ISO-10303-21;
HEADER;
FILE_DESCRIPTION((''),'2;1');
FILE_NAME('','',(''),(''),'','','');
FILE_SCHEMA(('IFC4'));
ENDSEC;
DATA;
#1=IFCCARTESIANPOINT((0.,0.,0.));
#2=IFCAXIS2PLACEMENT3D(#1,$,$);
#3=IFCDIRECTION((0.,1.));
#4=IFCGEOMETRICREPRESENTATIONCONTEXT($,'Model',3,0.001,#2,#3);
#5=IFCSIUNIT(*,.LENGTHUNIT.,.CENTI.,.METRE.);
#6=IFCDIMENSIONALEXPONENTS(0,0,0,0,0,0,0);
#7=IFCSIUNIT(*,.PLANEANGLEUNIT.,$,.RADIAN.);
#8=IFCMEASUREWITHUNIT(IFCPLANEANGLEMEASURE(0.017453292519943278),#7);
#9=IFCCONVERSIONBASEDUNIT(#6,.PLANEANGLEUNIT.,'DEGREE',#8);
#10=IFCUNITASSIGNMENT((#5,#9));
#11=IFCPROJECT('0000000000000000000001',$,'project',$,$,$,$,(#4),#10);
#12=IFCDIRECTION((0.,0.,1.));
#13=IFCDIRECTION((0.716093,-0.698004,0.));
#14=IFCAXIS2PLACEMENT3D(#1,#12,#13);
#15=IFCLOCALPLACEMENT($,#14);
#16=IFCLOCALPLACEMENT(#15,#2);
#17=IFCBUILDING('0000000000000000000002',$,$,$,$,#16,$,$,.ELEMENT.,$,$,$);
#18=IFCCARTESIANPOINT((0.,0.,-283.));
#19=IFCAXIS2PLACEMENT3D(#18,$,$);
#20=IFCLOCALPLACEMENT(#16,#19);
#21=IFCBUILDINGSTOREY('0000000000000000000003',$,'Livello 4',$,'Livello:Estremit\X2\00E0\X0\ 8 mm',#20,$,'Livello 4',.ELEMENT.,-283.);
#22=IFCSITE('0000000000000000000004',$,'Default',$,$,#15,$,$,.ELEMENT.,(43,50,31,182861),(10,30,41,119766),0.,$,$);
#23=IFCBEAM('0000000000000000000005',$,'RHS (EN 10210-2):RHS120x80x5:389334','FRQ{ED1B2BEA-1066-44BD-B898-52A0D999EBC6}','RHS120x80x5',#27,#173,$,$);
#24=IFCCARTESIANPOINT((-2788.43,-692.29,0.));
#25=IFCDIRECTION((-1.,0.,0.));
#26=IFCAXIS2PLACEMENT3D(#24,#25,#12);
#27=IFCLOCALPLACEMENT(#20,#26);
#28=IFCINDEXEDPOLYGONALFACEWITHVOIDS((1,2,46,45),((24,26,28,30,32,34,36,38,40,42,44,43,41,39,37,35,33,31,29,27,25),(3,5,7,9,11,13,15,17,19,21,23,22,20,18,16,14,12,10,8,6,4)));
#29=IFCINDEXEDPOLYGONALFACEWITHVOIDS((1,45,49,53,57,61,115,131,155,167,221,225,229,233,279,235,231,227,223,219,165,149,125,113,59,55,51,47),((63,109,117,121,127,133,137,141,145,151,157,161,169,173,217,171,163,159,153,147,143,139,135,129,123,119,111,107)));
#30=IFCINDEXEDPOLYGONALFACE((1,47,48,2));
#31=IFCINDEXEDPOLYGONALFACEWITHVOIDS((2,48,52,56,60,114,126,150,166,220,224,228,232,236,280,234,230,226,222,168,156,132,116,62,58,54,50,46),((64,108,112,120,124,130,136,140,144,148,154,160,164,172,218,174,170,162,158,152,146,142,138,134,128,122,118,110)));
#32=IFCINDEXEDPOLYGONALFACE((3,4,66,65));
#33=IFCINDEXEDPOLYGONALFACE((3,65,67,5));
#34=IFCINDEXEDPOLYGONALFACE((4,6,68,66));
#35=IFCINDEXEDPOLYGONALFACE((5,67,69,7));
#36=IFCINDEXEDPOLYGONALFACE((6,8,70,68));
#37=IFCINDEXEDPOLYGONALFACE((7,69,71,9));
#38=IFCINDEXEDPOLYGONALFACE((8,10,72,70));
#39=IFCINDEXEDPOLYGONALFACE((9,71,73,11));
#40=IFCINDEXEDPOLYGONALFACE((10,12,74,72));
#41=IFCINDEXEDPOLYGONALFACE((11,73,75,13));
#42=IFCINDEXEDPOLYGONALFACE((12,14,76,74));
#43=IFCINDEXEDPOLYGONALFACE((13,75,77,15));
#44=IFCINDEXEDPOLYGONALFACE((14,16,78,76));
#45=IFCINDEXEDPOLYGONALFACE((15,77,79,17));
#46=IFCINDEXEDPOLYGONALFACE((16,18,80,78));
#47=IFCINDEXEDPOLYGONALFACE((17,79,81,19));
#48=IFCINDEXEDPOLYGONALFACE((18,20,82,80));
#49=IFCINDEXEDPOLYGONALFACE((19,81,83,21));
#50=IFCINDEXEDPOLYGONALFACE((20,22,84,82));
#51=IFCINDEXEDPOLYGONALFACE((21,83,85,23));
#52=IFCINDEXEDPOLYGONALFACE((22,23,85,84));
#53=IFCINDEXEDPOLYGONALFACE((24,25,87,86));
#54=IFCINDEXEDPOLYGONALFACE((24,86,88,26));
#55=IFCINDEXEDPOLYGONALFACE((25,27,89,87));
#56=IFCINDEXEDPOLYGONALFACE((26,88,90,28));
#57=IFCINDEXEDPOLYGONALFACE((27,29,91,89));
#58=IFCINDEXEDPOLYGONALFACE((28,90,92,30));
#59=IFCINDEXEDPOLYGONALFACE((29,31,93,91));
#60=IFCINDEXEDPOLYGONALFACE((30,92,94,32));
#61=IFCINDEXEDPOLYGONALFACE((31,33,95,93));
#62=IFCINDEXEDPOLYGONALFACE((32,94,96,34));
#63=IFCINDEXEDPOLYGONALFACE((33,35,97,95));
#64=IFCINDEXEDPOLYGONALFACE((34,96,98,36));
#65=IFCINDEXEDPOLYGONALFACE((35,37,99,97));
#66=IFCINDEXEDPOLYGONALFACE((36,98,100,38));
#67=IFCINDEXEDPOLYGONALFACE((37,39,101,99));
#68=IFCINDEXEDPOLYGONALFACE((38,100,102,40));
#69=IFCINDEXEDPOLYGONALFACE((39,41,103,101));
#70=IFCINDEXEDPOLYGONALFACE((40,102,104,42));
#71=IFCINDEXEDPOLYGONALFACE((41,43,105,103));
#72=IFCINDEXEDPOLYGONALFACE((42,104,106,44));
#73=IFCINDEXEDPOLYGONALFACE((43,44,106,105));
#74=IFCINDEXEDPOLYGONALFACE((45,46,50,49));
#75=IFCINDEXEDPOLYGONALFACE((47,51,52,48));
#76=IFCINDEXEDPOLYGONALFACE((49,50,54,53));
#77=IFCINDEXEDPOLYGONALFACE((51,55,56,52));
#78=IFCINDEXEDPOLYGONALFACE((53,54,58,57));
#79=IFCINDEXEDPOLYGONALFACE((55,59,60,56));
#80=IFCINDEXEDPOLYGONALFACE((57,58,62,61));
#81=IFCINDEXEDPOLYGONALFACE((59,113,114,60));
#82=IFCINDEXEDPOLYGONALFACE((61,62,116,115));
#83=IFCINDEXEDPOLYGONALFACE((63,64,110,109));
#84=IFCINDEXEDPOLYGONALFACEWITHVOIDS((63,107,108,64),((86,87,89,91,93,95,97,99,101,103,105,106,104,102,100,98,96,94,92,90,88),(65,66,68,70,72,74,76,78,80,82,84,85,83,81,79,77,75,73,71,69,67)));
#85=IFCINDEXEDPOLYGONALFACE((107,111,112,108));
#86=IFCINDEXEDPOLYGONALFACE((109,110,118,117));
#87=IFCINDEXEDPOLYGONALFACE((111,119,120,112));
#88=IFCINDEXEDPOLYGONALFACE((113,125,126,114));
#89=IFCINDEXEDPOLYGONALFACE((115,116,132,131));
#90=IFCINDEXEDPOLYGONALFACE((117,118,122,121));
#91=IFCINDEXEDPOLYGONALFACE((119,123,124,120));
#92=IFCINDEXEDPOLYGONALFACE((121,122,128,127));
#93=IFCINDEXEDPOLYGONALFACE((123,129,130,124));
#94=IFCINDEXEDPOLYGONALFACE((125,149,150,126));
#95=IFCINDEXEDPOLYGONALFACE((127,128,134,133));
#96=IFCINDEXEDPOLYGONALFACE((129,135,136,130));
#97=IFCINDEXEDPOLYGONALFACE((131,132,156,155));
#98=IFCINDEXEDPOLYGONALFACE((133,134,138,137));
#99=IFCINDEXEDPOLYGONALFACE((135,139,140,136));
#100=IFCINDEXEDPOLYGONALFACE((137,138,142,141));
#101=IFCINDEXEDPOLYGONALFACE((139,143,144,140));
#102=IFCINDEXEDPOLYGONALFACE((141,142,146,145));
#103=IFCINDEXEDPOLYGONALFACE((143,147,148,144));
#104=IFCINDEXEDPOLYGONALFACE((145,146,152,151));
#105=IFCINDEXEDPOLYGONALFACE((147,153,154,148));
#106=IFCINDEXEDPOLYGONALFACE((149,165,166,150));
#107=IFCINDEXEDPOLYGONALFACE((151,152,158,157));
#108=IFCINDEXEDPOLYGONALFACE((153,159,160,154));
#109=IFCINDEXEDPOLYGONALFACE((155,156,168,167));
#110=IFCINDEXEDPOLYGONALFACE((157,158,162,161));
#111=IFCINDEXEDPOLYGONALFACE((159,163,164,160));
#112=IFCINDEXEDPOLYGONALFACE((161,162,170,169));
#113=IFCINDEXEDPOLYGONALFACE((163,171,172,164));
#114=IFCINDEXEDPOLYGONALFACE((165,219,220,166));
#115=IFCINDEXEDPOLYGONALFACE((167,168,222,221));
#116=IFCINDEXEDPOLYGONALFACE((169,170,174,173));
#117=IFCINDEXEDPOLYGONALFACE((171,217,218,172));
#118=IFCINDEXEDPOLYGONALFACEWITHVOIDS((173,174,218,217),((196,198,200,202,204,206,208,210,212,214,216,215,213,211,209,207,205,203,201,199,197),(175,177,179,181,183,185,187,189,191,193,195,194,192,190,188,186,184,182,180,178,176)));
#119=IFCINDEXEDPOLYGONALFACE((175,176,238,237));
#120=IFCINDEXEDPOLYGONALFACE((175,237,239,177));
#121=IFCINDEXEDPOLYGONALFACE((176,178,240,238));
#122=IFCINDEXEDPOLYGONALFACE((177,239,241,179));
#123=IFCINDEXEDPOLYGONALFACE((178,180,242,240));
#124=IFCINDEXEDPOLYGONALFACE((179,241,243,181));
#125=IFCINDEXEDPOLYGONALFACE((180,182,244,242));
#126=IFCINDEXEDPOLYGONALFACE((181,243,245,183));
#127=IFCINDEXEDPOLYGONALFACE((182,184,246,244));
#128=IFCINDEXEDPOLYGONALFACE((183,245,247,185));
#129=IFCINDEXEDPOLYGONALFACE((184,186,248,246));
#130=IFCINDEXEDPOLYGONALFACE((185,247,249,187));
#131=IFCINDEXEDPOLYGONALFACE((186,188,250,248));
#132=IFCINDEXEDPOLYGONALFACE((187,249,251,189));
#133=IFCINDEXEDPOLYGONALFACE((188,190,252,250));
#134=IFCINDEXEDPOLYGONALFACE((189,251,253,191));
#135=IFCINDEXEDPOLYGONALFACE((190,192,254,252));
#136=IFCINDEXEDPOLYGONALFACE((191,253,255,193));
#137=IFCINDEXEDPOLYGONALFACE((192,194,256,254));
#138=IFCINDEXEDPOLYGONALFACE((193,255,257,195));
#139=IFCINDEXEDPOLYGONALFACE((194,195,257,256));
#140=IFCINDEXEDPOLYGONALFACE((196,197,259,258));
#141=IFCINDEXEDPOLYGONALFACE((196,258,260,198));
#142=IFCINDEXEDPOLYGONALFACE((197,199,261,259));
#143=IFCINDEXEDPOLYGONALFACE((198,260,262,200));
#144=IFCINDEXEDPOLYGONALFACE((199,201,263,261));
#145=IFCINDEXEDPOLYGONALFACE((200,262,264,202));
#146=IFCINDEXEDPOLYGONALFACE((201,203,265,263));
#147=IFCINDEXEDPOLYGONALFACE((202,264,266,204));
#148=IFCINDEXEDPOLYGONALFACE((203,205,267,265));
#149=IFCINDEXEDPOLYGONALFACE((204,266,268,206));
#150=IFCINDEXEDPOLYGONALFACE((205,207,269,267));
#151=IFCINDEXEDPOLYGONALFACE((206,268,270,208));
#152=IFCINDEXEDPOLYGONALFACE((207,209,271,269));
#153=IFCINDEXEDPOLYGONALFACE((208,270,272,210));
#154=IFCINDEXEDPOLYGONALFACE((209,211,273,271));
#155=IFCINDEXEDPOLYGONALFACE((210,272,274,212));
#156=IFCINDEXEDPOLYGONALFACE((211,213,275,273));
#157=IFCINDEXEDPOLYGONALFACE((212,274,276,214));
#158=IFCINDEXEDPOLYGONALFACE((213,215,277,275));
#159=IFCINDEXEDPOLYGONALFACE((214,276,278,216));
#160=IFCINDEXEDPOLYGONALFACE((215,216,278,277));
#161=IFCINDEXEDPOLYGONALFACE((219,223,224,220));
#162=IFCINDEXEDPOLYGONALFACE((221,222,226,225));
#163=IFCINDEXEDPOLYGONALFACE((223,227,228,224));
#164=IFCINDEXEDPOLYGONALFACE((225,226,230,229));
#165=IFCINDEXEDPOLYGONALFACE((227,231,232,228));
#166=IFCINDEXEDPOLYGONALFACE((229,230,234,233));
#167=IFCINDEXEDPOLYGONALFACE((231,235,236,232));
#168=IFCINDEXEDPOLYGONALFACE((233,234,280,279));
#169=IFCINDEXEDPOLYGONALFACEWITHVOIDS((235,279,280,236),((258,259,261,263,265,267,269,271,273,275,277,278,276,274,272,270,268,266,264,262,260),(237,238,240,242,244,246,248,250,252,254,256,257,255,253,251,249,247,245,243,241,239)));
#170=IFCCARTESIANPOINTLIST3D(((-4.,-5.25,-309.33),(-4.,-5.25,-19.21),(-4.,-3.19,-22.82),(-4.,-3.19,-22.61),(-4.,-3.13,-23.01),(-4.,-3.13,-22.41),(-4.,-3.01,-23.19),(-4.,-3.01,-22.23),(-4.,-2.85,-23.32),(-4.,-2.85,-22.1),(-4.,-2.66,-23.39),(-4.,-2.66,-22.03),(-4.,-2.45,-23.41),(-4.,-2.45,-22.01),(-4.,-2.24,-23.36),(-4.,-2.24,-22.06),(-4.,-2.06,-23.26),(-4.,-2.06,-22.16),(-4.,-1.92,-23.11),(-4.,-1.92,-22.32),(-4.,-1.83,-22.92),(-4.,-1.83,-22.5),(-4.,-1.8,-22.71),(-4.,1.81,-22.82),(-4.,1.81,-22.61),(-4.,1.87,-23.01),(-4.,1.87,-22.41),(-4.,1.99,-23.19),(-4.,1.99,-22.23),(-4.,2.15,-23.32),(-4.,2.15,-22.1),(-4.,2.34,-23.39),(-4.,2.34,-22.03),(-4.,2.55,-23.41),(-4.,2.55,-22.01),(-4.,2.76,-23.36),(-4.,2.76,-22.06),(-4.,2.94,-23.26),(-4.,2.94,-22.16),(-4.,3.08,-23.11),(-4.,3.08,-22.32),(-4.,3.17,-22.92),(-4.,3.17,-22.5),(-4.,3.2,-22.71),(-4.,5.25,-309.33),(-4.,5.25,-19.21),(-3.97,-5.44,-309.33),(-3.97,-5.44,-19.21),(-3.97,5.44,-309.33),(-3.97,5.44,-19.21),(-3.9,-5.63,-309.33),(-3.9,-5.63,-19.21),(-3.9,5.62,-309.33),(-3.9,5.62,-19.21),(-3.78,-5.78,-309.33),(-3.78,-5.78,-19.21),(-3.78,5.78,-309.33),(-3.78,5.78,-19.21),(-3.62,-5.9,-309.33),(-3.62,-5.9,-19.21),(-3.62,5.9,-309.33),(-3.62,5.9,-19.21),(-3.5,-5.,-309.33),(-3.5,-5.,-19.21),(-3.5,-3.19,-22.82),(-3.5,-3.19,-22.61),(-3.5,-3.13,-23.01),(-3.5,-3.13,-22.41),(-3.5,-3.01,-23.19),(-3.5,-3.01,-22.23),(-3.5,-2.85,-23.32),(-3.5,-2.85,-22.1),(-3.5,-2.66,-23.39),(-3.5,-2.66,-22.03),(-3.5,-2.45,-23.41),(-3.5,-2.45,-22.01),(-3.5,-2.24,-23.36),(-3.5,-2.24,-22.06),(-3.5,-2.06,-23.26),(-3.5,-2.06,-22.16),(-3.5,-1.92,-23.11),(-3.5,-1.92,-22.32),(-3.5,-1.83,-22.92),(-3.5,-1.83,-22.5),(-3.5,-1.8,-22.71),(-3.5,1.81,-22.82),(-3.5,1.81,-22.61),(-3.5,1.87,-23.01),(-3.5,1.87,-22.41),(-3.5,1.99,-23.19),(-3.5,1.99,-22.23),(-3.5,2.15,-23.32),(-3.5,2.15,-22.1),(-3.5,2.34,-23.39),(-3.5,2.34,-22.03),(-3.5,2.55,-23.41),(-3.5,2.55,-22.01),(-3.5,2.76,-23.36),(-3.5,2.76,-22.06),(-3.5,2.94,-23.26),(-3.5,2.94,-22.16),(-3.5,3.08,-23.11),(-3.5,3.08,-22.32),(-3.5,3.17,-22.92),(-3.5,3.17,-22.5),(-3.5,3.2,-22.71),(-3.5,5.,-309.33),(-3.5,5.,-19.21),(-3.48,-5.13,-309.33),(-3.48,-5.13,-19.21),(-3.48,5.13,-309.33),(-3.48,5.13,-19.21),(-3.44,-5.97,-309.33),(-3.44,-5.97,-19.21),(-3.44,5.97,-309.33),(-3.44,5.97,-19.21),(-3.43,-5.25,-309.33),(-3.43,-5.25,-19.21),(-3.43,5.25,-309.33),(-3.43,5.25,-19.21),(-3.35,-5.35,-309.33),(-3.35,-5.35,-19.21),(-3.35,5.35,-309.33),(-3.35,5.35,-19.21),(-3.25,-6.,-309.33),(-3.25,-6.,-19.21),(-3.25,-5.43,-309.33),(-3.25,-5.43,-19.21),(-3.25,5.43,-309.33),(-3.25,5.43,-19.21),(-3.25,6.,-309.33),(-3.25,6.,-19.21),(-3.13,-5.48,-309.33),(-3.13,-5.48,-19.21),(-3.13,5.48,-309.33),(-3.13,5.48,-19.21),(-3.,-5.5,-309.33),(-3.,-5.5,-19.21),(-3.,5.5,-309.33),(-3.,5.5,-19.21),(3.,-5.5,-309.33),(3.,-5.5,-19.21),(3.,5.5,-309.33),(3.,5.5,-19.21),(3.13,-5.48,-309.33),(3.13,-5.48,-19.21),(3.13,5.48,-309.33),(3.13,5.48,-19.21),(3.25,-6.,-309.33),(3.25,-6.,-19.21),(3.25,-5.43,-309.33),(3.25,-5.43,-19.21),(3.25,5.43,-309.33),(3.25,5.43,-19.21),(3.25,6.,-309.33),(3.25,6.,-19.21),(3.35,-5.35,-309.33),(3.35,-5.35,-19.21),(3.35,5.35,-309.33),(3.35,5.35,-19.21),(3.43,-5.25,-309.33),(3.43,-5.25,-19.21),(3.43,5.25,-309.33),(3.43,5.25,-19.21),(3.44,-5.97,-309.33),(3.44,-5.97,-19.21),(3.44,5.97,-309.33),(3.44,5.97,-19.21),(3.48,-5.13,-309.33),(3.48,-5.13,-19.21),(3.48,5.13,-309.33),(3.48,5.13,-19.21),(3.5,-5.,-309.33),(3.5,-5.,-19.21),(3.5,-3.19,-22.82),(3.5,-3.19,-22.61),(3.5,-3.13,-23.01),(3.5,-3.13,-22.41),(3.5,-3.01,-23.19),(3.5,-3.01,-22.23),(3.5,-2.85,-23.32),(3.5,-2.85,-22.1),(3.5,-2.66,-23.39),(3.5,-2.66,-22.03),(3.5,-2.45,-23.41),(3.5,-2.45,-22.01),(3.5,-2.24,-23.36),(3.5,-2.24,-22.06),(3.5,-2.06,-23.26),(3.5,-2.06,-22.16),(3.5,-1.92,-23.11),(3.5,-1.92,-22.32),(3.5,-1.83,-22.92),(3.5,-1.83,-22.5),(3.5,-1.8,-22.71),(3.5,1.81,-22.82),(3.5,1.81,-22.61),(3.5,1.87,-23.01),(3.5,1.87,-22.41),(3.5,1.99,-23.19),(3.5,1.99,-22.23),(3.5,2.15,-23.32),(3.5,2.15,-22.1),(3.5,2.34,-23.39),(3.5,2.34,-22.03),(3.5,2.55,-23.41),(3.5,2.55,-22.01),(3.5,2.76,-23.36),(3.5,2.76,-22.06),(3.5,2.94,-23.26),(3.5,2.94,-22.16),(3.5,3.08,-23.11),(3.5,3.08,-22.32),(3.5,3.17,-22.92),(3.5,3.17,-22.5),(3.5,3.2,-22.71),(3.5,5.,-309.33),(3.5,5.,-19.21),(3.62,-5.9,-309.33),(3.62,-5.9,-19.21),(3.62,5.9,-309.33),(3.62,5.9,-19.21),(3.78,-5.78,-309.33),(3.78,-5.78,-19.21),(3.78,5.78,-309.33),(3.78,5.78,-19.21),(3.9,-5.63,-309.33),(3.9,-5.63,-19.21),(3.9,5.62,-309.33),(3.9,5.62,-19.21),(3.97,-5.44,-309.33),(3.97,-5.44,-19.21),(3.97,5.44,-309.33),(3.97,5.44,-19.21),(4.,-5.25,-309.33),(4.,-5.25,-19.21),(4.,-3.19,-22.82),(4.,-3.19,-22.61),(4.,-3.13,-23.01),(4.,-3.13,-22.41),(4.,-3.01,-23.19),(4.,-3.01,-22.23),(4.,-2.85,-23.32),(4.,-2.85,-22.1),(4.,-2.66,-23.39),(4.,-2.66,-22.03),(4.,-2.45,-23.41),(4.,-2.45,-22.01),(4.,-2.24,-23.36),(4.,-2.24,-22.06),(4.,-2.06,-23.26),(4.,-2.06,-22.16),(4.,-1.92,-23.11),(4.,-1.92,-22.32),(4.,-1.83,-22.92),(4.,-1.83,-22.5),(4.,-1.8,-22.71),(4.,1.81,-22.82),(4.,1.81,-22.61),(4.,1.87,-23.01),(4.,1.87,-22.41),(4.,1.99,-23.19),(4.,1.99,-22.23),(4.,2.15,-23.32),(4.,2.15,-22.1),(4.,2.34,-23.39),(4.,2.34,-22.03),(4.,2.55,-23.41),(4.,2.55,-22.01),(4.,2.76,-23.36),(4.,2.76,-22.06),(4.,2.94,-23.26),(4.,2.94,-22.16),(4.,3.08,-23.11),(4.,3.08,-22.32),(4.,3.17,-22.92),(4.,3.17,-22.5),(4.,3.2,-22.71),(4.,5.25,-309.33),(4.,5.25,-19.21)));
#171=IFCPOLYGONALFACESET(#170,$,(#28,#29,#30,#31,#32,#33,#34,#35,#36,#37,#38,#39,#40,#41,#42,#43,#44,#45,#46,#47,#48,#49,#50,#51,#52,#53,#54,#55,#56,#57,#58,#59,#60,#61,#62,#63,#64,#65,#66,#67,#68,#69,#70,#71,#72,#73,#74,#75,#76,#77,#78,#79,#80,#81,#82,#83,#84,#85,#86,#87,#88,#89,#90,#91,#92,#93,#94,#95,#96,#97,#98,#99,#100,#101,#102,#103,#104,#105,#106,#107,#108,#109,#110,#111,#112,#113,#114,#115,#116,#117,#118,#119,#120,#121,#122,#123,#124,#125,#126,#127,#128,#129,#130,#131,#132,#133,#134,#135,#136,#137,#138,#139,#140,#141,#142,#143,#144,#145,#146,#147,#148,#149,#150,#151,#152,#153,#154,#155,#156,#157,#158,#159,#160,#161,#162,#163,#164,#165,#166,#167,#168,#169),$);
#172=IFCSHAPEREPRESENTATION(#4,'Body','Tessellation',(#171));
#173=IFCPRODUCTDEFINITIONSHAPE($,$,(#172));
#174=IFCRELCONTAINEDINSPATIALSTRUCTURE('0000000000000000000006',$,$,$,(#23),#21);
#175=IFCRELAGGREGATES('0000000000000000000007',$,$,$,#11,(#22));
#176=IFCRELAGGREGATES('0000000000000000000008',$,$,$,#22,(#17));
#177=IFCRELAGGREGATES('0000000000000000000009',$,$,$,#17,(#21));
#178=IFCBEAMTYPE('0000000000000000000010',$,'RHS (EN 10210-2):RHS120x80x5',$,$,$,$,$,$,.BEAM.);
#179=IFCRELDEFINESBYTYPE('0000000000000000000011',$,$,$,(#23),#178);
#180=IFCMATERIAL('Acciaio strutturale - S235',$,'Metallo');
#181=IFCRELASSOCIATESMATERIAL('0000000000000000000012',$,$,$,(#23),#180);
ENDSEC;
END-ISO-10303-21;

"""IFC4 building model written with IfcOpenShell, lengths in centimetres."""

from ifc_helpers import new_model, entity, si_unit, converted_unit, direction, frame, frame_2d, origin, origin_2d, place, context, project, spatial, hollow_rectangle, circle, extrude, clip, halfspace, material, type_object, element, save


model = new_model("IFC4")

# Units and contexts
model_context = context("Model", 3, precision=0.001, world=origin(), true_north=direction((0.0, 1.0)))
ifc_project = project(units=[si_unit("LENGTHUNIT", "METRE", prefix="CENTI"), converted_unit("PLANEANGLEUNIT", "DEGREE", entity("IfcPlaneAngleMeasure", 0.017453292519943278), si_unit("PLANEANGLEUNIT", "RADIAN"), dimensions=[0, 0, 0, 0, 0, 0, 0])], contexts=[model_context])

# Site, building, storey
site_placement = place(None, frame((0.0, 0.0, 0.0), z_axis=(0.0, 0.0, 1.0), x_axis=(0.716093, -0.698004, 0.0)))
site = spatial("IfcSite", under=ifc_project, at=site_placement, Name="Default", CompositionType="ELEMENT", RefLatitude=(43, 50, 31, 182861), RefLongitude=(10, 30, 41, 119766), RefElevation=0.0)
building_placement = place(site_placement, origin())
building = spatial("IfcBuilding", under=site, at=building_placement, CompositionType="ELEMENT")
storey_placement = place(building_placement, frame((0.0, 0.0, -283.0)))
storey = spatial("IfcBuildingStorey", under=building, at=storey_placement, Name="Livello 4", ObjectType="Livello:Estremità 8 mm", LongName="Livello 4", CompositionType="ELEMENT", Elevation=-283.0)

# Shared definitions
ifc_material = material(Name="Acciaio strutturale - S235", Category="Metallo")

# Beam, openings
beam_type = type_object("IfcBeamType", Name="RHS (EN 10210-2):RHS120x80x5", PredefinedType="BEAM")
beam_1_placement = place(storey_placement, frame((-2788.43, -692.29, 0.0), z_axis=(-1.0, 0.0, 0.0), x_axis=(0.0, 0.0, 1.0)))
beam_1 = element("IfcBeam", 1, at=beam_1_placement, inside=storey, type_object=beam_type, material=ifc_material, Name="RHS (EN 10210-2):RHS120x80x5:389334", Description="FRQ{ED1B2BEA-1066-44BD-B898-52A0D999EBC6}", ObjectType="RHS120x80x5", context=model_context, shape_type="Clipping", body=[
    clip(clip(extrude(hollow_rectangle(XDim=8.0, YDim=12.0, WallThickness=0.5, InnerFilletRadius=0.5, OuterFilletRadius=0.75, at=origin_2d()), origin(), (0.0, 0.0, -1.0), 328.54), halfspace(frame((283.0, 692.29, -19.21), z_axis=(0.0, 0.0, -1.0), x_axis=(0.0, 1.0, 0.0)), True)), halfspace(frame((283.0, 692.29, -309.33), z_axis=(0.0, 0.0, 1.0), x_axis=(0.0, -1.0, 0.0)), True)),
])
opening_1_placement = place(beam_1_placement, frame((-4.05, 0.0, -22.71), z_axis=(1.0, 0.0, 0.0), x_axis=(0.0, 1.0, 0.0)))
element("IfcOpeningElement", 2, at=opening_1_placement, cuts=beam_1, ObjectType="Opening", context=model_context, shape_type="SweptSolid", body=[
    extrude(circle(Radius=0.7, at=frame_2d((2.5, 0.0), x_axis=(1.0, 0.0))), origin(), (0.0, 0.0, 1.0), 0.6),
])
opening_2_placement = place(beam_1_placement, frame((-4.05, 0.0, -22.71), z_axis=(1.0, 0.0, 0.0), x_axis=(0.0, 1.0, 0.0)))
element("IfcOpeningElement", 3, at=opening_2_placement, cuts=beam_1, ObjectType="Opening", context=model_context, shape_type="SweptSolid", body=[
    extrude(circle(Radius=0.7, at=frame_2d((-2.5, 0.0), x_axis=(1.0, 0.0))), origin(), (0.0, 0.0, 1.0), 0.6),
])
opening_3_placement = place(beam_1_placement, frame((3.45, 0.0, -22.71), z_axis=(1.0, 0.0, 0.0), x_axis=(0.0, 1.0, 0.0)))
element("IfcOpeningElement", 4, at=opening_3_placement, cuts=beam_1, ObjectType="Opening", context=model_context, shape_type="SweptSolid", body=[
    extrude(circle(Radius=0.7, at=frame_2d((2.5, 0.0), x_axis=(1.0, 0.0))), origin(), (0.0, 0.0, 1.0), 0.6),
])
opening_4_placement = place(beam_1_placement, frame((3.45, 0.0, -22.71), z_axis=(1.0, 0.0, 0.0), x_axis=(0.0, 1.0, 0.0)))
element("IfcOpeningElement", 5, at=opening_4_placement, cuts=beam_1, ObjectType="Opening", context=model_context, shape_type="SweptSolid", body=[
    extrude(circle(Radius=0.7, at=frame_2d((-2.5, 0.0), x_axis=(1.0, 0.0))), origin(), (0.0, 0.0, 1.0), 0.6),
])

save(model, "model.ifc")
